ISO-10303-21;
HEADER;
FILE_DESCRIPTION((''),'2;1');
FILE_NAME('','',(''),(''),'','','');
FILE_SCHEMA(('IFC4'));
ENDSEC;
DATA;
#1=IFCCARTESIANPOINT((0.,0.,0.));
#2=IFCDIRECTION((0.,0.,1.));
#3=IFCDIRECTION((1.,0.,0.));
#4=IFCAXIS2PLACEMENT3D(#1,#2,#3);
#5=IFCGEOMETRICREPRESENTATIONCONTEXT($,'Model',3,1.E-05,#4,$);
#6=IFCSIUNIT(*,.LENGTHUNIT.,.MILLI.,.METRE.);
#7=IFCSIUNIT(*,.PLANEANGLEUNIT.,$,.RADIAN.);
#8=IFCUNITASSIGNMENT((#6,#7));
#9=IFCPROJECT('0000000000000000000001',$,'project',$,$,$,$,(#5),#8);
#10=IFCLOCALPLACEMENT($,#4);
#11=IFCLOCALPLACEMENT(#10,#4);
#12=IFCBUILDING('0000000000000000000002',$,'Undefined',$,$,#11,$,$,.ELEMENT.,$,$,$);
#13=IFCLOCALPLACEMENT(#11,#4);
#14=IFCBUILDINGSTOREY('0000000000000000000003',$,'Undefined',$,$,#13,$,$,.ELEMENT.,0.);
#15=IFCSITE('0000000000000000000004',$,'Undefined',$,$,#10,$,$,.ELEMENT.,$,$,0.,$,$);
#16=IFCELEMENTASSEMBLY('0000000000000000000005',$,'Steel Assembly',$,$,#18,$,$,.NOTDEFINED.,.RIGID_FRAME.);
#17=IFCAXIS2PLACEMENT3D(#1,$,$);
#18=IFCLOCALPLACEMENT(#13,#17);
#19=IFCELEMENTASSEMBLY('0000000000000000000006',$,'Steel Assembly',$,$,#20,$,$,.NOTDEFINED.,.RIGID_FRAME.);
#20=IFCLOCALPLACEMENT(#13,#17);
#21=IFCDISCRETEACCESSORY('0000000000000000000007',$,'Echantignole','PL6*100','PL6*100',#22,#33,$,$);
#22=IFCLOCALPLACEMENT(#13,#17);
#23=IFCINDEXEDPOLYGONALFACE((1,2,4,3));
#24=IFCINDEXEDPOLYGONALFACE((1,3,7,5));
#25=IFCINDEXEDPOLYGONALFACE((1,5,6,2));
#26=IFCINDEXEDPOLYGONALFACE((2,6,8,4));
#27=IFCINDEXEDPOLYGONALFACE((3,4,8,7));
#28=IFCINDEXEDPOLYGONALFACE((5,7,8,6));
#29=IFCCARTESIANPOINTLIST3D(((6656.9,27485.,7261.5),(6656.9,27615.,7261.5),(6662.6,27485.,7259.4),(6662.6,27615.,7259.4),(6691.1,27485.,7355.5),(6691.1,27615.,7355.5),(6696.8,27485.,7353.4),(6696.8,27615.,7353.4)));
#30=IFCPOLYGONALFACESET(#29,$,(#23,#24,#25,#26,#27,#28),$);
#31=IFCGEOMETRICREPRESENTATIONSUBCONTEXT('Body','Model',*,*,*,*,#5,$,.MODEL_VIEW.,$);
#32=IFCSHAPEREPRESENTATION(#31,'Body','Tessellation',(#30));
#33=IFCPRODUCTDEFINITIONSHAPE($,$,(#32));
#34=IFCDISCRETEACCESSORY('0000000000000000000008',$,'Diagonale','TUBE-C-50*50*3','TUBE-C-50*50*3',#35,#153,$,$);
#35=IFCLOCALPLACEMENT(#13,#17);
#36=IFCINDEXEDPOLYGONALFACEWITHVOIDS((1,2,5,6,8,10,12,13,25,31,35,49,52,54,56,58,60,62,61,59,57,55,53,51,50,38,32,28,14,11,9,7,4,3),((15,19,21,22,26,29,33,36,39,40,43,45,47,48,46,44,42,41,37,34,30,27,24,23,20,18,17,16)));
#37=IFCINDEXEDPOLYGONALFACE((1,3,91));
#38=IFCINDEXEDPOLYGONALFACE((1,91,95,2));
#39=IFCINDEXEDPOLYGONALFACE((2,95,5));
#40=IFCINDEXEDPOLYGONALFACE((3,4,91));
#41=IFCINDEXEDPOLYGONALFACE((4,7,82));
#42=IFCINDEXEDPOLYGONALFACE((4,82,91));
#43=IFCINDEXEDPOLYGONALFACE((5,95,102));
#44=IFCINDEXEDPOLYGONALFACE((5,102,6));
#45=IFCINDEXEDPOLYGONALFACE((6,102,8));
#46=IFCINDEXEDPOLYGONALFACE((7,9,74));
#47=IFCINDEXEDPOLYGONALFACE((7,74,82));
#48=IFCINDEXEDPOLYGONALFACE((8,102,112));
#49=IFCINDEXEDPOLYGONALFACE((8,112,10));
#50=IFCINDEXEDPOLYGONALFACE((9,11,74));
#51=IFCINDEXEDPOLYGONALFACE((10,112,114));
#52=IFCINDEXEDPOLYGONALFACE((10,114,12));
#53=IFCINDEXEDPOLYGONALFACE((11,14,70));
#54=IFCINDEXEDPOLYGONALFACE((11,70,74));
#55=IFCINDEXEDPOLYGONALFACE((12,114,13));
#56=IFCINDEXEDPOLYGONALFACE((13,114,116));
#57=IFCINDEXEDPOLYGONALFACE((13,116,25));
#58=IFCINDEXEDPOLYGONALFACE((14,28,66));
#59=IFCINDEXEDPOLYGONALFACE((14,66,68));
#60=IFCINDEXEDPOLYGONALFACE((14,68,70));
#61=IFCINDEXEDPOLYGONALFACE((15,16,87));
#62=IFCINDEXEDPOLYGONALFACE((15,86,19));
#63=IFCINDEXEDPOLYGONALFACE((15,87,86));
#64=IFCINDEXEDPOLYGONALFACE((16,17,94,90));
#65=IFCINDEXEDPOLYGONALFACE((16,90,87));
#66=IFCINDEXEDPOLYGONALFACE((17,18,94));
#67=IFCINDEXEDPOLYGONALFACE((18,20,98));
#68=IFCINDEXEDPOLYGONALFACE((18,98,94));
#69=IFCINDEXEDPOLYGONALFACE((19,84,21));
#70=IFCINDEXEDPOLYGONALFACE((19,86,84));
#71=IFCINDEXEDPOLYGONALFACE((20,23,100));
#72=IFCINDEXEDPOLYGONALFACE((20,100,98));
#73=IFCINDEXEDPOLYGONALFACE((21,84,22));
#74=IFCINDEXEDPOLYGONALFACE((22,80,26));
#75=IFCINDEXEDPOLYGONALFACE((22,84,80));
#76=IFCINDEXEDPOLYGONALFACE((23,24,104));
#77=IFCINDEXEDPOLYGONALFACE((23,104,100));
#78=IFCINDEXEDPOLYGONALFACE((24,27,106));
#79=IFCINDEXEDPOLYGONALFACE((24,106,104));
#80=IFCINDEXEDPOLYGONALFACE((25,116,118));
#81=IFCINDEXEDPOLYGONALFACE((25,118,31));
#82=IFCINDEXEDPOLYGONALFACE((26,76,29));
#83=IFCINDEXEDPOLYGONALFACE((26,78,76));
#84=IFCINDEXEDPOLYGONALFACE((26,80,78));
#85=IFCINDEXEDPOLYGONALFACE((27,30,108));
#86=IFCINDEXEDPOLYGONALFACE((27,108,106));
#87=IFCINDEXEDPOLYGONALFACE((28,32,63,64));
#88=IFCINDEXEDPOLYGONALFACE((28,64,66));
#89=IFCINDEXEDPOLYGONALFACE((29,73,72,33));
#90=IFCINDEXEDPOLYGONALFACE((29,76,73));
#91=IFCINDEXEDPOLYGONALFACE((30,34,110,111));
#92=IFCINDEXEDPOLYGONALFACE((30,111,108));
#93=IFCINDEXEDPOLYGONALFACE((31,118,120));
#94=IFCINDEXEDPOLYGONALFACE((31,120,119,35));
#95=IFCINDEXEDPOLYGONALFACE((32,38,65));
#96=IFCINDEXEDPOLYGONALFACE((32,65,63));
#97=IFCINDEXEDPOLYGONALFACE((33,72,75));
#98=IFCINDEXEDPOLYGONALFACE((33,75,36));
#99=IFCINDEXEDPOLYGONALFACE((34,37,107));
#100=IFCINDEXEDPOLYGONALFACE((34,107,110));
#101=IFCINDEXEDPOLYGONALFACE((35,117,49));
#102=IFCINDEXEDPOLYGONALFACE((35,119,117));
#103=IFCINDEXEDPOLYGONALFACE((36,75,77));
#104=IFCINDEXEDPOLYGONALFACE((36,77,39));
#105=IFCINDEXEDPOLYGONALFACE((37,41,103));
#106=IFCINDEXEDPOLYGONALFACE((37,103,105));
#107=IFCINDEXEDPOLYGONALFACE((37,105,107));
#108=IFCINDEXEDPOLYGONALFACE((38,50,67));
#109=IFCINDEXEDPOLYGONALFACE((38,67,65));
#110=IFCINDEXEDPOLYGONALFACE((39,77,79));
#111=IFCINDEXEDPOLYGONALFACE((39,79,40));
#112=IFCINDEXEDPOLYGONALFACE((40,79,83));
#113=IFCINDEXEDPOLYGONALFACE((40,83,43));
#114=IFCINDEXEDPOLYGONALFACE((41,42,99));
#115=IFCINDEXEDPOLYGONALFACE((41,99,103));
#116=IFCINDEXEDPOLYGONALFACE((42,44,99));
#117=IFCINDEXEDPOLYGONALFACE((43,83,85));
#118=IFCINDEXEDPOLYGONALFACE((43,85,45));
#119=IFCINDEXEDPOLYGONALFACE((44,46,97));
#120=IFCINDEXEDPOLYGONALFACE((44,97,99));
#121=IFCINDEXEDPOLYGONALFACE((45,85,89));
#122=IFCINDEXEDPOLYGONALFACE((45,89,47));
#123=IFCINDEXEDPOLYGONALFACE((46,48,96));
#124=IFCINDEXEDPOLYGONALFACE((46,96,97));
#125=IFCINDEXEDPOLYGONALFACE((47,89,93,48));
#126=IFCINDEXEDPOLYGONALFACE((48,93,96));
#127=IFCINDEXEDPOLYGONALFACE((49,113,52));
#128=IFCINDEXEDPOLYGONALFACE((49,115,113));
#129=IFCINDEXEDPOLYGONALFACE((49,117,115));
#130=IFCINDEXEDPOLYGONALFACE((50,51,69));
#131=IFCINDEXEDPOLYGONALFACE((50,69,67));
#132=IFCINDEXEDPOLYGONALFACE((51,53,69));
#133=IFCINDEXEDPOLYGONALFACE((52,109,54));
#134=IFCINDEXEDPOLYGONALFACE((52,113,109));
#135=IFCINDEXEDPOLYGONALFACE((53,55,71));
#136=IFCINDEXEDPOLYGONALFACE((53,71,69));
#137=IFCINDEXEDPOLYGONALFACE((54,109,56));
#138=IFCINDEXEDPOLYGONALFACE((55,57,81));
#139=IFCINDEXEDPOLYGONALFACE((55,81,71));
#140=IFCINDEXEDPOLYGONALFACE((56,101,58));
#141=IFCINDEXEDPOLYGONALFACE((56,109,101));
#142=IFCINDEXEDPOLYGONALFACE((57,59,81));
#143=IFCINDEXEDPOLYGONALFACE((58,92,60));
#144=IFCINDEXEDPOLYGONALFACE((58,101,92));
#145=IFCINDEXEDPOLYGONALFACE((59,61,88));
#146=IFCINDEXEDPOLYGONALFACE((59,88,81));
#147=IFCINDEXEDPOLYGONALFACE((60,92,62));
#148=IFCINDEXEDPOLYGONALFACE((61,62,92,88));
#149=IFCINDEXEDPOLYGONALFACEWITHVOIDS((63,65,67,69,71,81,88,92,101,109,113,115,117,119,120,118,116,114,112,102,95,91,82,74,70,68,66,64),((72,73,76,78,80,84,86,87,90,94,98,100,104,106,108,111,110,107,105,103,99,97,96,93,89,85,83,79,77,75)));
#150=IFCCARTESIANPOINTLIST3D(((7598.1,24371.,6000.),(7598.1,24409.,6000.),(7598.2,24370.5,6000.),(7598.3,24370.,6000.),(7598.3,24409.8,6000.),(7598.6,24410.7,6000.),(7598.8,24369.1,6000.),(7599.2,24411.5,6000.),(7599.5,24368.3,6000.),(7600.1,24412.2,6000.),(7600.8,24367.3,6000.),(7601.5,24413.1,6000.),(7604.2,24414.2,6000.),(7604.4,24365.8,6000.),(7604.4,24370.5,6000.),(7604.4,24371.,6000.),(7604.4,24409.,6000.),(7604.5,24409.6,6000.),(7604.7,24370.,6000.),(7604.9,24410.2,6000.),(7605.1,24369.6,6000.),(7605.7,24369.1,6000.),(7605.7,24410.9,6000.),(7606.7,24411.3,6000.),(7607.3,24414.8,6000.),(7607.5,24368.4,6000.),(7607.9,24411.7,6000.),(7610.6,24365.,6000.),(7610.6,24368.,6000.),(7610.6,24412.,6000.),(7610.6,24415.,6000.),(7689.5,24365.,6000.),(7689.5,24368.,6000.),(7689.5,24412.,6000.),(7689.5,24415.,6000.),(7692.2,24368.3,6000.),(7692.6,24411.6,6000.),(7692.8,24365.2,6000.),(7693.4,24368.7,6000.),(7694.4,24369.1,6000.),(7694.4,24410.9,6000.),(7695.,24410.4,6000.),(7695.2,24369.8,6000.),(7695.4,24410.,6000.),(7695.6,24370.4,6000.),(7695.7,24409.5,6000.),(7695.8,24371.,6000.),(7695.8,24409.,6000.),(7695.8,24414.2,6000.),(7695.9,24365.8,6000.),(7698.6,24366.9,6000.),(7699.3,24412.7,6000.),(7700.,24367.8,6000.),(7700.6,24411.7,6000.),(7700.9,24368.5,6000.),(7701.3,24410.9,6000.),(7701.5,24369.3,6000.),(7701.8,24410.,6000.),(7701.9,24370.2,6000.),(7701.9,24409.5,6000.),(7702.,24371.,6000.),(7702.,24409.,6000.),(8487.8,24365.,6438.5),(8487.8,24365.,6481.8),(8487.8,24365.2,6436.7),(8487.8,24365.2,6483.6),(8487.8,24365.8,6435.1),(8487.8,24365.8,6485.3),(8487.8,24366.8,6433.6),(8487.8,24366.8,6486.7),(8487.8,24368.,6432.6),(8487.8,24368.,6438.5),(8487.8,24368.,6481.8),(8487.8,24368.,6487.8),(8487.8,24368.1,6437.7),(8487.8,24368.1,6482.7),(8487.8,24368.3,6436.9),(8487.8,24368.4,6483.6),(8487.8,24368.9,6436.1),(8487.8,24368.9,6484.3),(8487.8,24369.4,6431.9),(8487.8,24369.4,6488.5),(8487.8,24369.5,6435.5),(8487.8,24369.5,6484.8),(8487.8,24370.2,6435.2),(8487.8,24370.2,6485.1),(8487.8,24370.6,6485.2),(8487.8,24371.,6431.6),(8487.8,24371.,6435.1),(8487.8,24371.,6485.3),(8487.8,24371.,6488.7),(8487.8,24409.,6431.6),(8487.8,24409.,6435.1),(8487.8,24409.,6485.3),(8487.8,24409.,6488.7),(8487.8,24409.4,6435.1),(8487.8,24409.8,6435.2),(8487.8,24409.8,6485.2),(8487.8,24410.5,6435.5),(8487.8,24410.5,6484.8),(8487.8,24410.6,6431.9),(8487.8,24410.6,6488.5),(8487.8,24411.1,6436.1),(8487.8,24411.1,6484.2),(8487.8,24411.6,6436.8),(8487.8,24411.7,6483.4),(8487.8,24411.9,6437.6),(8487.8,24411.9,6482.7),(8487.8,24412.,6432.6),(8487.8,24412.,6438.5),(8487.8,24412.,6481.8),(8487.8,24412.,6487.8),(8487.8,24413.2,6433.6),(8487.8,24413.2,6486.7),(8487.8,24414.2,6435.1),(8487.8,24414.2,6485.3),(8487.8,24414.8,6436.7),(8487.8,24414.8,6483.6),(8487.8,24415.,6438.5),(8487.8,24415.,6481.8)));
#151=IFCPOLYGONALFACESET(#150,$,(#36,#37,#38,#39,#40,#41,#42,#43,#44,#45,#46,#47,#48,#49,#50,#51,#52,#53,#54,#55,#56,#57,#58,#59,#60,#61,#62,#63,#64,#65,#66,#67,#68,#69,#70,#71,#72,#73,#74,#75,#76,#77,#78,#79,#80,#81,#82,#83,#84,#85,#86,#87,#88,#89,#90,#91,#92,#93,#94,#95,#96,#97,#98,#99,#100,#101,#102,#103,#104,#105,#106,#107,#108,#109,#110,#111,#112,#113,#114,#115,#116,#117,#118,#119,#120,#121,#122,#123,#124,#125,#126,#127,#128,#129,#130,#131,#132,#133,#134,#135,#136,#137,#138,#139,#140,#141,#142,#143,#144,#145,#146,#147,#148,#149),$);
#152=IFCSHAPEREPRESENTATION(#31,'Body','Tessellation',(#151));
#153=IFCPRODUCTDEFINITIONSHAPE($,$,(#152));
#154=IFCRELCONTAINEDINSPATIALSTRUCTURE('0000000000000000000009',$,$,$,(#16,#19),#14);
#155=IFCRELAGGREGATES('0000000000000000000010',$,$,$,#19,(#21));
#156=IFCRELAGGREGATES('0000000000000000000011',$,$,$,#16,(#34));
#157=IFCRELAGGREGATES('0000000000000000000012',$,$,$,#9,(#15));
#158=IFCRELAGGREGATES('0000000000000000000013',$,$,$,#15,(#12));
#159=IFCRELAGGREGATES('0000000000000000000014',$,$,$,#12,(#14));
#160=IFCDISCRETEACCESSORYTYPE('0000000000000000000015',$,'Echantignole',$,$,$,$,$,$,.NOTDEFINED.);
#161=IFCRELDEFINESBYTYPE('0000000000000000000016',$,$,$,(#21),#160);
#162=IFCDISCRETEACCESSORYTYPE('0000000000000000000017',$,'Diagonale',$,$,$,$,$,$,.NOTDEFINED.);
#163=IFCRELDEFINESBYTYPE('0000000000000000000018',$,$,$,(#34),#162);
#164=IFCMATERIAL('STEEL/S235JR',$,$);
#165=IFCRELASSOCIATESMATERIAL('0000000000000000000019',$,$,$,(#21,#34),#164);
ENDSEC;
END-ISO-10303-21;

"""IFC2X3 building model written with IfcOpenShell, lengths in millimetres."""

from ifc_helpers import new_model, si_unit, frame, origin_with_axes, origin_2d_with_axis, place, context, subcontext, project, spatial, polyline, hollow_rectangle, outline, extrude, clip, halfspace, material, type_object, element, aggregate, save


model = new_model("IFC2X3")

# Units and contexts
model_context = context("Model", 3, precision=1e-05, world=origin_with_axes())
body_context = subcontext(model_context, "Body", "Model", "MODEL_VIEW")
ifc_project = project(units=[si_unit("LENGTHUNIT", "METRE", prefix="MILLI"), si_unit("PLANEANGLEUNIT", "RADIAN")], contexts=[model_context])

# Site, building, storey
site_placement = place(None, origin_with_axes())
site = spatial("IfcSite", under=ifc_project, at=site_placement, Name="Undefined", CompositionType="ELEMENT", RefElevation=0.0)
building_placement = place(site_placement, origin_with_axes())
building = spatial("IfcBuilding", under=site, at=building_placement, Name="Undefined", CompositionType="ELEMENT")
storey_placement = place(building_placement, origin_with_axes())
storey = spatial("IfcBuildingStorey", under=building, at=storey_placement, Name="Undefined", CompositionType="ELEMENT", Elevation=0.0)

# Shared definitions
ifc_material_1 = material(Name="STEEL/S235JR")

# Element assembly
assembly_1_placement = place(storey_placement, origin_with_axes())
assembly_1 = element("IfcElementAssembly", 1, at=assembly_1_placement, inside=storey, Name="Steel Assembly", AssemblyPlace="NOTDEFINED", PredefinedType="RIGID_FRAME")

# Shared definitions
discrete_accessory_type_1 = type_object("IfcDiscreteAccessoryType", Name="Echantignole")

# Element assembly, discrete accessory
assembly_2_placement = place(storey_placement, origin_with_axes())
assembly_2 = element("IfcElementAssembly", 2, at=assembly_2_placement, inside=storey, Name="Steel Assembly", AssemblyPlace="NOTDEFINED", PredefinedType="RIGID_FRAME")
discrete_accessory_1_placement = place(assembly_2_placement, frame((6676.8, 27485.0, 7307.5), z_axis=(0.939693, 0.0, -0.34202), x_axis=(0.0, 1.0, 0.0)))
discrete_accessory_1 = element("IfcDiscreteAccessory", 3, at=discrete_accessory_1_placement, type_object=discrete_accessory_type_1, material=ifc_material_1, Name="Echantignole", Description="PL6*100", ObjectType="PL6*100", context=body_context, shape_type="SweptSolid", body=[
    extrude(outline(polyline([(0.0, 50.0), (130.0, 50.0), (130.0, -50.0), (0.0, -50.0), (0.0, 50.0)])), frame((0.0, 0.0, -3.0), z_axis=(0.0, 0.0, 1.0), x_axis=(1.0, 0.0, 0.0)), (0.0, 0.0, 1.0), 6.0),
])
aggregate(assembly_2, [discrete_accessory_1])

# Discrete accessory
discrete_accessory_type_2 = type_object("IfcDiscreteAccessoryType", Name="Diagonale")
discrete_accessory_2_placement = place(assembly_1_placement, frame((7610.2, 24390.0, 5978.1), z_axis=(-0.481434, 0.0, 0.876482), x_axis=(0.876482, 0.0, 0.481434)))
discrete_accessory_2 = element("IfcDiscreteAccessory", 4, at=discrete_accessory_2_placement, type_object=discrete_accessory_type_2, material=ifc_material_1, Name="Diagonale", Description="TUBE-C-50*50*3", ObjectType="TUBE-C-50*50*3", context=body_context, shape_type="Clipping", body=[
    clip(clip(extrude(hollow_rectangle(XDim=50.0, YDim=50.0, WallThickness=3.0, InnerFilletRadius=3.0, OuterFilletRadius=6.0, at=origin_2d_with_axis()), frame((1061.2, 0.0, 0.0), z_axis=(-1.0, 0.0, 0.0), x_axis=(0.0, -1.0, 0.0)), (0.0, 0.0, 1.0), 1075.5), halfspace(frame((1015.1, 0.0, 25.0), z_axis=(-0.876482, 0.0, 0.481434), x_axis=(-0.481434, 0.0, -0.876482)), True)), halfspace(frame((41.8, 0.0, 2.1), z_axis=(-0.481434, 0.0, -0.876482), x_axis=(0.876482, 0.0, -0.481434)), False)),
])

aggregate(assembly_1, [discrete_accessory_2])

save(model, "model.ifc")
